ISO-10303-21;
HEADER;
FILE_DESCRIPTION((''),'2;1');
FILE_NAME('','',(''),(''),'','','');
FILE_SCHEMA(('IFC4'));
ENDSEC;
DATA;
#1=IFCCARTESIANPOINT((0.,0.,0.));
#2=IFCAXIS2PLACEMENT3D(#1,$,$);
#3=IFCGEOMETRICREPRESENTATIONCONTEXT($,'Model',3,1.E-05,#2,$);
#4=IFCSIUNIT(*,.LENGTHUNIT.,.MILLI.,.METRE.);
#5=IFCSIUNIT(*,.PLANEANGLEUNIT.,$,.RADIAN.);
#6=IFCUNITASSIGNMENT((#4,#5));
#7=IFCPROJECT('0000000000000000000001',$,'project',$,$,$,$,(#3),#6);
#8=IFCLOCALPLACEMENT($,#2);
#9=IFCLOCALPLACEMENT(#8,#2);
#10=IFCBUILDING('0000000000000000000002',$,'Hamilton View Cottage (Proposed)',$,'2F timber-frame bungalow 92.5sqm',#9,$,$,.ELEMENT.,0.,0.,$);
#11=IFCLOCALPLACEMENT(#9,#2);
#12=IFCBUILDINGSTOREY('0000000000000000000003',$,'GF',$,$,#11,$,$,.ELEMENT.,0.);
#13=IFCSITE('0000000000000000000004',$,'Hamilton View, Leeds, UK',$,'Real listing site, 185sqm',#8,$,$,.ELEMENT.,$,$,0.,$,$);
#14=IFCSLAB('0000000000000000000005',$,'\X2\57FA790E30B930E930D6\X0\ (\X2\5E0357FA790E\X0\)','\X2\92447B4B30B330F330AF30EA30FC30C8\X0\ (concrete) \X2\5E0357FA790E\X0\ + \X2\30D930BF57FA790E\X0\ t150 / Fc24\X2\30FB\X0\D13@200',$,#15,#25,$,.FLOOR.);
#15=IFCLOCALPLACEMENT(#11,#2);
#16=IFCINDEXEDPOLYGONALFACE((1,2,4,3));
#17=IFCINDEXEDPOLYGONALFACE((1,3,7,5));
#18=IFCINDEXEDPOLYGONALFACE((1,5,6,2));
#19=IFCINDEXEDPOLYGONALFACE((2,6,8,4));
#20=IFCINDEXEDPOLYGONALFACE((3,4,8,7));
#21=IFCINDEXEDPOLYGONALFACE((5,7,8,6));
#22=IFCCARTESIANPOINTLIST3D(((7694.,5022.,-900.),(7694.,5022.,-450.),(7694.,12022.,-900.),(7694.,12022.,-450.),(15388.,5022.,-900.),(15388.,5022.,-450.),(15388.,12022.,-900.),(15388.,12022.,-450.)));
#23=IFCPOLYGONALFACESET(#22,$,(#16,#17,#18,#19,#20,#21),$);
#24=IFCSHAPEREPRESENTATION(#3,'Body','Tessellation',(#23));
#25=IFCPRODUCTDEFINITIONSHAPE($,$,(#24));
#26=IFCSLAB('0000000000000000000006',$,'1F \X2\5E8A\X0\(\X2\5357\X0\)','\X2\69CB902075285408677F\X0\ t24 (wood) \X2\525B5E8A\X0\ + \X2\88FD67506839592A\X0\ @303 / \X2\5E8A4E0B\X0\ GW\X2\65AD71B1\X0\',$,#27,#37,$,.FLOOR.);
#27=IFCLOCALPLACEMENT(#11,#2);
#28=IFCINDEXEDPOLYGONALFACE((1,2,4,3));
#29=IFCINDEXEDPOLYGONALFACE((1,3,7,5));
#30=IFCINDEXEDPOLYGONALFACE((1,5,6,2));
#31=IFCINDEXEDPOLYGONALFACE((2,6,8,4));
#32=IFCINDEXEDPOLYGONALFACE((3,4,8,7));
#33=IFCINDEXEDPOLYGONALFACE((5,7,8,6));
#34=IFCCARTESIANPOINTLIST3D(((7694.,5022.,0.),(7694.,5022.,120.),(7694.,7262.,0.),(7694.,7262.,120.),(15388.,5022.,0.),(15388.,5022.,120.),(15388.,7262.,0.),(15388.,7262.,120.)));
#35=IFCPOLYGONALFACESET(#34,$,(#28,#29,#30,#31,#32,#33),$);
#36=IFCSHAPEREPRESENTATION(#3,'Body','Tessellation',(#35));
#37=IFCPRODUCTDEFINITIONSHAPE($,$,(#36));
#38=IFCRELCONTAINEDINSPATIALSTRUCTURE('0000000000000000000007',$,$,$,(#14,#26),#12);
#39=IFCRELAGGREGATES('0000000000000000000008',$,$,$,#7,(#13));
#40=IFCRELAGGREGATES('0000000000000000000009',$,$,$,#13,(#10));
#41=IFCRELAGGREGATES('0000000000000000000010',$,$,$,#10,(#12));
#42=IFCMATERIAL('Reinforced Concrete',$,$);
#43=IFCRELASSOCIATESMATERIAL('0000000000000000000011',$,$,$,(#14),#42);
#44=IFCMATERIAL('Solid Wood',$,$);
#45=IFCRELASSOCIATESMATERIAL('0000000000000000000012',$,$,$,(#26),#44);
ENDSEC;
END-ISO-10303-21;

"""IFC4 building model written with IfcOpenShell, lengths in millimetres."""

from ifc_helpers import new_model, si_unit, frame, frame_2d, origin, place, context, project, spatial, rectangle, extrude, material, element, save


model = new_model("IFC4")

# Units and contexts
model_context = context("Model", 3, precision=1e-05, world=origin())
ifc_project = project(units=[si_unit("LENGTHUNIT", "METRE", prefix="MILLI"), si_unit("PLANEANGLEUNIT", "RADIAN")], contexts=[model_context])

# Site, building, storey
site_placement = place(None, origin())
site = spatial("IfcSite", under=ifc_project, at=site_placement, Name="Hamilton View, Leeds, UK", ObjectType="Real listing site, 185sqm", CompositionType="ELEMENT", RefElevation=0.0)
building_placement = place(site_placement, origin())
building = spatial("IfcBuilding", under=site, at=building_placement, Name="Hamilton View Cottage (Proposed)", ObjectType="2F timber-frame bungalow 92.5sqm", CompositionType="ELEMENT", ElevationOfRefHeight=0.0, ElevationOfTerrain=0.0)
storey_placement = place(building_placement, origin())
storey = spatial("IfcBuildingStorey", under=building, at=storey_placement, Name="GF", CompositionType="ELEMENT", Elevation=0.0)

# Slabs
ifc_material_1 = material(Name="Reinforced Concrete")
slab_1_placement = place(storey_placement, frame((3847.0, 2511.0, -450.0)))
element("IfcSlab", 1, at=slab_1_placement, inside=storey, material=ifc_material_1, Name="基礎スラブ (布基礎)", Description="鉄筋コンクリート (concrete) 布基礎 + ベタ基礎 t150 / Fc24・D13@200", PredefinedType="FLOOR", context=model_context, shape_type="SweptSolid", body=[
    extrude(rectangle(XDim=7694.0, YDim=7000.0, at=frame_2d((3847.0, 3500.0))), frame((3847.0, 2511.0, -450.0)), (0.0, 0.0, 1.0), 450.0),
])
ifc_material_2 = material(Name="Solid Wood")
slab_2_placement = place(storey_placement, frame((3847.0, 2511.0, 0.0)))
element("IfcSlab", 2, at=slab_2_placement, inside=storey, material=ifc_material_2, Name="1F 床(南)", Description="構造用合板 t24 (wood) 剛床 + 製材根太 @303 / 床下 GW断熱", PredefinedType="FLOOR", context=model_context, shape_type="SweptSolid", body=[
    extrude(rectangle(XDim=7694.0, YDim=2240.0, at=frame_2d((3847.0, 1120.0))), frame((3847.0, 2511.0, 0.0)), (0.0, 0.0, 1.0), 120.0),
])

save(model, "model.ifc")
